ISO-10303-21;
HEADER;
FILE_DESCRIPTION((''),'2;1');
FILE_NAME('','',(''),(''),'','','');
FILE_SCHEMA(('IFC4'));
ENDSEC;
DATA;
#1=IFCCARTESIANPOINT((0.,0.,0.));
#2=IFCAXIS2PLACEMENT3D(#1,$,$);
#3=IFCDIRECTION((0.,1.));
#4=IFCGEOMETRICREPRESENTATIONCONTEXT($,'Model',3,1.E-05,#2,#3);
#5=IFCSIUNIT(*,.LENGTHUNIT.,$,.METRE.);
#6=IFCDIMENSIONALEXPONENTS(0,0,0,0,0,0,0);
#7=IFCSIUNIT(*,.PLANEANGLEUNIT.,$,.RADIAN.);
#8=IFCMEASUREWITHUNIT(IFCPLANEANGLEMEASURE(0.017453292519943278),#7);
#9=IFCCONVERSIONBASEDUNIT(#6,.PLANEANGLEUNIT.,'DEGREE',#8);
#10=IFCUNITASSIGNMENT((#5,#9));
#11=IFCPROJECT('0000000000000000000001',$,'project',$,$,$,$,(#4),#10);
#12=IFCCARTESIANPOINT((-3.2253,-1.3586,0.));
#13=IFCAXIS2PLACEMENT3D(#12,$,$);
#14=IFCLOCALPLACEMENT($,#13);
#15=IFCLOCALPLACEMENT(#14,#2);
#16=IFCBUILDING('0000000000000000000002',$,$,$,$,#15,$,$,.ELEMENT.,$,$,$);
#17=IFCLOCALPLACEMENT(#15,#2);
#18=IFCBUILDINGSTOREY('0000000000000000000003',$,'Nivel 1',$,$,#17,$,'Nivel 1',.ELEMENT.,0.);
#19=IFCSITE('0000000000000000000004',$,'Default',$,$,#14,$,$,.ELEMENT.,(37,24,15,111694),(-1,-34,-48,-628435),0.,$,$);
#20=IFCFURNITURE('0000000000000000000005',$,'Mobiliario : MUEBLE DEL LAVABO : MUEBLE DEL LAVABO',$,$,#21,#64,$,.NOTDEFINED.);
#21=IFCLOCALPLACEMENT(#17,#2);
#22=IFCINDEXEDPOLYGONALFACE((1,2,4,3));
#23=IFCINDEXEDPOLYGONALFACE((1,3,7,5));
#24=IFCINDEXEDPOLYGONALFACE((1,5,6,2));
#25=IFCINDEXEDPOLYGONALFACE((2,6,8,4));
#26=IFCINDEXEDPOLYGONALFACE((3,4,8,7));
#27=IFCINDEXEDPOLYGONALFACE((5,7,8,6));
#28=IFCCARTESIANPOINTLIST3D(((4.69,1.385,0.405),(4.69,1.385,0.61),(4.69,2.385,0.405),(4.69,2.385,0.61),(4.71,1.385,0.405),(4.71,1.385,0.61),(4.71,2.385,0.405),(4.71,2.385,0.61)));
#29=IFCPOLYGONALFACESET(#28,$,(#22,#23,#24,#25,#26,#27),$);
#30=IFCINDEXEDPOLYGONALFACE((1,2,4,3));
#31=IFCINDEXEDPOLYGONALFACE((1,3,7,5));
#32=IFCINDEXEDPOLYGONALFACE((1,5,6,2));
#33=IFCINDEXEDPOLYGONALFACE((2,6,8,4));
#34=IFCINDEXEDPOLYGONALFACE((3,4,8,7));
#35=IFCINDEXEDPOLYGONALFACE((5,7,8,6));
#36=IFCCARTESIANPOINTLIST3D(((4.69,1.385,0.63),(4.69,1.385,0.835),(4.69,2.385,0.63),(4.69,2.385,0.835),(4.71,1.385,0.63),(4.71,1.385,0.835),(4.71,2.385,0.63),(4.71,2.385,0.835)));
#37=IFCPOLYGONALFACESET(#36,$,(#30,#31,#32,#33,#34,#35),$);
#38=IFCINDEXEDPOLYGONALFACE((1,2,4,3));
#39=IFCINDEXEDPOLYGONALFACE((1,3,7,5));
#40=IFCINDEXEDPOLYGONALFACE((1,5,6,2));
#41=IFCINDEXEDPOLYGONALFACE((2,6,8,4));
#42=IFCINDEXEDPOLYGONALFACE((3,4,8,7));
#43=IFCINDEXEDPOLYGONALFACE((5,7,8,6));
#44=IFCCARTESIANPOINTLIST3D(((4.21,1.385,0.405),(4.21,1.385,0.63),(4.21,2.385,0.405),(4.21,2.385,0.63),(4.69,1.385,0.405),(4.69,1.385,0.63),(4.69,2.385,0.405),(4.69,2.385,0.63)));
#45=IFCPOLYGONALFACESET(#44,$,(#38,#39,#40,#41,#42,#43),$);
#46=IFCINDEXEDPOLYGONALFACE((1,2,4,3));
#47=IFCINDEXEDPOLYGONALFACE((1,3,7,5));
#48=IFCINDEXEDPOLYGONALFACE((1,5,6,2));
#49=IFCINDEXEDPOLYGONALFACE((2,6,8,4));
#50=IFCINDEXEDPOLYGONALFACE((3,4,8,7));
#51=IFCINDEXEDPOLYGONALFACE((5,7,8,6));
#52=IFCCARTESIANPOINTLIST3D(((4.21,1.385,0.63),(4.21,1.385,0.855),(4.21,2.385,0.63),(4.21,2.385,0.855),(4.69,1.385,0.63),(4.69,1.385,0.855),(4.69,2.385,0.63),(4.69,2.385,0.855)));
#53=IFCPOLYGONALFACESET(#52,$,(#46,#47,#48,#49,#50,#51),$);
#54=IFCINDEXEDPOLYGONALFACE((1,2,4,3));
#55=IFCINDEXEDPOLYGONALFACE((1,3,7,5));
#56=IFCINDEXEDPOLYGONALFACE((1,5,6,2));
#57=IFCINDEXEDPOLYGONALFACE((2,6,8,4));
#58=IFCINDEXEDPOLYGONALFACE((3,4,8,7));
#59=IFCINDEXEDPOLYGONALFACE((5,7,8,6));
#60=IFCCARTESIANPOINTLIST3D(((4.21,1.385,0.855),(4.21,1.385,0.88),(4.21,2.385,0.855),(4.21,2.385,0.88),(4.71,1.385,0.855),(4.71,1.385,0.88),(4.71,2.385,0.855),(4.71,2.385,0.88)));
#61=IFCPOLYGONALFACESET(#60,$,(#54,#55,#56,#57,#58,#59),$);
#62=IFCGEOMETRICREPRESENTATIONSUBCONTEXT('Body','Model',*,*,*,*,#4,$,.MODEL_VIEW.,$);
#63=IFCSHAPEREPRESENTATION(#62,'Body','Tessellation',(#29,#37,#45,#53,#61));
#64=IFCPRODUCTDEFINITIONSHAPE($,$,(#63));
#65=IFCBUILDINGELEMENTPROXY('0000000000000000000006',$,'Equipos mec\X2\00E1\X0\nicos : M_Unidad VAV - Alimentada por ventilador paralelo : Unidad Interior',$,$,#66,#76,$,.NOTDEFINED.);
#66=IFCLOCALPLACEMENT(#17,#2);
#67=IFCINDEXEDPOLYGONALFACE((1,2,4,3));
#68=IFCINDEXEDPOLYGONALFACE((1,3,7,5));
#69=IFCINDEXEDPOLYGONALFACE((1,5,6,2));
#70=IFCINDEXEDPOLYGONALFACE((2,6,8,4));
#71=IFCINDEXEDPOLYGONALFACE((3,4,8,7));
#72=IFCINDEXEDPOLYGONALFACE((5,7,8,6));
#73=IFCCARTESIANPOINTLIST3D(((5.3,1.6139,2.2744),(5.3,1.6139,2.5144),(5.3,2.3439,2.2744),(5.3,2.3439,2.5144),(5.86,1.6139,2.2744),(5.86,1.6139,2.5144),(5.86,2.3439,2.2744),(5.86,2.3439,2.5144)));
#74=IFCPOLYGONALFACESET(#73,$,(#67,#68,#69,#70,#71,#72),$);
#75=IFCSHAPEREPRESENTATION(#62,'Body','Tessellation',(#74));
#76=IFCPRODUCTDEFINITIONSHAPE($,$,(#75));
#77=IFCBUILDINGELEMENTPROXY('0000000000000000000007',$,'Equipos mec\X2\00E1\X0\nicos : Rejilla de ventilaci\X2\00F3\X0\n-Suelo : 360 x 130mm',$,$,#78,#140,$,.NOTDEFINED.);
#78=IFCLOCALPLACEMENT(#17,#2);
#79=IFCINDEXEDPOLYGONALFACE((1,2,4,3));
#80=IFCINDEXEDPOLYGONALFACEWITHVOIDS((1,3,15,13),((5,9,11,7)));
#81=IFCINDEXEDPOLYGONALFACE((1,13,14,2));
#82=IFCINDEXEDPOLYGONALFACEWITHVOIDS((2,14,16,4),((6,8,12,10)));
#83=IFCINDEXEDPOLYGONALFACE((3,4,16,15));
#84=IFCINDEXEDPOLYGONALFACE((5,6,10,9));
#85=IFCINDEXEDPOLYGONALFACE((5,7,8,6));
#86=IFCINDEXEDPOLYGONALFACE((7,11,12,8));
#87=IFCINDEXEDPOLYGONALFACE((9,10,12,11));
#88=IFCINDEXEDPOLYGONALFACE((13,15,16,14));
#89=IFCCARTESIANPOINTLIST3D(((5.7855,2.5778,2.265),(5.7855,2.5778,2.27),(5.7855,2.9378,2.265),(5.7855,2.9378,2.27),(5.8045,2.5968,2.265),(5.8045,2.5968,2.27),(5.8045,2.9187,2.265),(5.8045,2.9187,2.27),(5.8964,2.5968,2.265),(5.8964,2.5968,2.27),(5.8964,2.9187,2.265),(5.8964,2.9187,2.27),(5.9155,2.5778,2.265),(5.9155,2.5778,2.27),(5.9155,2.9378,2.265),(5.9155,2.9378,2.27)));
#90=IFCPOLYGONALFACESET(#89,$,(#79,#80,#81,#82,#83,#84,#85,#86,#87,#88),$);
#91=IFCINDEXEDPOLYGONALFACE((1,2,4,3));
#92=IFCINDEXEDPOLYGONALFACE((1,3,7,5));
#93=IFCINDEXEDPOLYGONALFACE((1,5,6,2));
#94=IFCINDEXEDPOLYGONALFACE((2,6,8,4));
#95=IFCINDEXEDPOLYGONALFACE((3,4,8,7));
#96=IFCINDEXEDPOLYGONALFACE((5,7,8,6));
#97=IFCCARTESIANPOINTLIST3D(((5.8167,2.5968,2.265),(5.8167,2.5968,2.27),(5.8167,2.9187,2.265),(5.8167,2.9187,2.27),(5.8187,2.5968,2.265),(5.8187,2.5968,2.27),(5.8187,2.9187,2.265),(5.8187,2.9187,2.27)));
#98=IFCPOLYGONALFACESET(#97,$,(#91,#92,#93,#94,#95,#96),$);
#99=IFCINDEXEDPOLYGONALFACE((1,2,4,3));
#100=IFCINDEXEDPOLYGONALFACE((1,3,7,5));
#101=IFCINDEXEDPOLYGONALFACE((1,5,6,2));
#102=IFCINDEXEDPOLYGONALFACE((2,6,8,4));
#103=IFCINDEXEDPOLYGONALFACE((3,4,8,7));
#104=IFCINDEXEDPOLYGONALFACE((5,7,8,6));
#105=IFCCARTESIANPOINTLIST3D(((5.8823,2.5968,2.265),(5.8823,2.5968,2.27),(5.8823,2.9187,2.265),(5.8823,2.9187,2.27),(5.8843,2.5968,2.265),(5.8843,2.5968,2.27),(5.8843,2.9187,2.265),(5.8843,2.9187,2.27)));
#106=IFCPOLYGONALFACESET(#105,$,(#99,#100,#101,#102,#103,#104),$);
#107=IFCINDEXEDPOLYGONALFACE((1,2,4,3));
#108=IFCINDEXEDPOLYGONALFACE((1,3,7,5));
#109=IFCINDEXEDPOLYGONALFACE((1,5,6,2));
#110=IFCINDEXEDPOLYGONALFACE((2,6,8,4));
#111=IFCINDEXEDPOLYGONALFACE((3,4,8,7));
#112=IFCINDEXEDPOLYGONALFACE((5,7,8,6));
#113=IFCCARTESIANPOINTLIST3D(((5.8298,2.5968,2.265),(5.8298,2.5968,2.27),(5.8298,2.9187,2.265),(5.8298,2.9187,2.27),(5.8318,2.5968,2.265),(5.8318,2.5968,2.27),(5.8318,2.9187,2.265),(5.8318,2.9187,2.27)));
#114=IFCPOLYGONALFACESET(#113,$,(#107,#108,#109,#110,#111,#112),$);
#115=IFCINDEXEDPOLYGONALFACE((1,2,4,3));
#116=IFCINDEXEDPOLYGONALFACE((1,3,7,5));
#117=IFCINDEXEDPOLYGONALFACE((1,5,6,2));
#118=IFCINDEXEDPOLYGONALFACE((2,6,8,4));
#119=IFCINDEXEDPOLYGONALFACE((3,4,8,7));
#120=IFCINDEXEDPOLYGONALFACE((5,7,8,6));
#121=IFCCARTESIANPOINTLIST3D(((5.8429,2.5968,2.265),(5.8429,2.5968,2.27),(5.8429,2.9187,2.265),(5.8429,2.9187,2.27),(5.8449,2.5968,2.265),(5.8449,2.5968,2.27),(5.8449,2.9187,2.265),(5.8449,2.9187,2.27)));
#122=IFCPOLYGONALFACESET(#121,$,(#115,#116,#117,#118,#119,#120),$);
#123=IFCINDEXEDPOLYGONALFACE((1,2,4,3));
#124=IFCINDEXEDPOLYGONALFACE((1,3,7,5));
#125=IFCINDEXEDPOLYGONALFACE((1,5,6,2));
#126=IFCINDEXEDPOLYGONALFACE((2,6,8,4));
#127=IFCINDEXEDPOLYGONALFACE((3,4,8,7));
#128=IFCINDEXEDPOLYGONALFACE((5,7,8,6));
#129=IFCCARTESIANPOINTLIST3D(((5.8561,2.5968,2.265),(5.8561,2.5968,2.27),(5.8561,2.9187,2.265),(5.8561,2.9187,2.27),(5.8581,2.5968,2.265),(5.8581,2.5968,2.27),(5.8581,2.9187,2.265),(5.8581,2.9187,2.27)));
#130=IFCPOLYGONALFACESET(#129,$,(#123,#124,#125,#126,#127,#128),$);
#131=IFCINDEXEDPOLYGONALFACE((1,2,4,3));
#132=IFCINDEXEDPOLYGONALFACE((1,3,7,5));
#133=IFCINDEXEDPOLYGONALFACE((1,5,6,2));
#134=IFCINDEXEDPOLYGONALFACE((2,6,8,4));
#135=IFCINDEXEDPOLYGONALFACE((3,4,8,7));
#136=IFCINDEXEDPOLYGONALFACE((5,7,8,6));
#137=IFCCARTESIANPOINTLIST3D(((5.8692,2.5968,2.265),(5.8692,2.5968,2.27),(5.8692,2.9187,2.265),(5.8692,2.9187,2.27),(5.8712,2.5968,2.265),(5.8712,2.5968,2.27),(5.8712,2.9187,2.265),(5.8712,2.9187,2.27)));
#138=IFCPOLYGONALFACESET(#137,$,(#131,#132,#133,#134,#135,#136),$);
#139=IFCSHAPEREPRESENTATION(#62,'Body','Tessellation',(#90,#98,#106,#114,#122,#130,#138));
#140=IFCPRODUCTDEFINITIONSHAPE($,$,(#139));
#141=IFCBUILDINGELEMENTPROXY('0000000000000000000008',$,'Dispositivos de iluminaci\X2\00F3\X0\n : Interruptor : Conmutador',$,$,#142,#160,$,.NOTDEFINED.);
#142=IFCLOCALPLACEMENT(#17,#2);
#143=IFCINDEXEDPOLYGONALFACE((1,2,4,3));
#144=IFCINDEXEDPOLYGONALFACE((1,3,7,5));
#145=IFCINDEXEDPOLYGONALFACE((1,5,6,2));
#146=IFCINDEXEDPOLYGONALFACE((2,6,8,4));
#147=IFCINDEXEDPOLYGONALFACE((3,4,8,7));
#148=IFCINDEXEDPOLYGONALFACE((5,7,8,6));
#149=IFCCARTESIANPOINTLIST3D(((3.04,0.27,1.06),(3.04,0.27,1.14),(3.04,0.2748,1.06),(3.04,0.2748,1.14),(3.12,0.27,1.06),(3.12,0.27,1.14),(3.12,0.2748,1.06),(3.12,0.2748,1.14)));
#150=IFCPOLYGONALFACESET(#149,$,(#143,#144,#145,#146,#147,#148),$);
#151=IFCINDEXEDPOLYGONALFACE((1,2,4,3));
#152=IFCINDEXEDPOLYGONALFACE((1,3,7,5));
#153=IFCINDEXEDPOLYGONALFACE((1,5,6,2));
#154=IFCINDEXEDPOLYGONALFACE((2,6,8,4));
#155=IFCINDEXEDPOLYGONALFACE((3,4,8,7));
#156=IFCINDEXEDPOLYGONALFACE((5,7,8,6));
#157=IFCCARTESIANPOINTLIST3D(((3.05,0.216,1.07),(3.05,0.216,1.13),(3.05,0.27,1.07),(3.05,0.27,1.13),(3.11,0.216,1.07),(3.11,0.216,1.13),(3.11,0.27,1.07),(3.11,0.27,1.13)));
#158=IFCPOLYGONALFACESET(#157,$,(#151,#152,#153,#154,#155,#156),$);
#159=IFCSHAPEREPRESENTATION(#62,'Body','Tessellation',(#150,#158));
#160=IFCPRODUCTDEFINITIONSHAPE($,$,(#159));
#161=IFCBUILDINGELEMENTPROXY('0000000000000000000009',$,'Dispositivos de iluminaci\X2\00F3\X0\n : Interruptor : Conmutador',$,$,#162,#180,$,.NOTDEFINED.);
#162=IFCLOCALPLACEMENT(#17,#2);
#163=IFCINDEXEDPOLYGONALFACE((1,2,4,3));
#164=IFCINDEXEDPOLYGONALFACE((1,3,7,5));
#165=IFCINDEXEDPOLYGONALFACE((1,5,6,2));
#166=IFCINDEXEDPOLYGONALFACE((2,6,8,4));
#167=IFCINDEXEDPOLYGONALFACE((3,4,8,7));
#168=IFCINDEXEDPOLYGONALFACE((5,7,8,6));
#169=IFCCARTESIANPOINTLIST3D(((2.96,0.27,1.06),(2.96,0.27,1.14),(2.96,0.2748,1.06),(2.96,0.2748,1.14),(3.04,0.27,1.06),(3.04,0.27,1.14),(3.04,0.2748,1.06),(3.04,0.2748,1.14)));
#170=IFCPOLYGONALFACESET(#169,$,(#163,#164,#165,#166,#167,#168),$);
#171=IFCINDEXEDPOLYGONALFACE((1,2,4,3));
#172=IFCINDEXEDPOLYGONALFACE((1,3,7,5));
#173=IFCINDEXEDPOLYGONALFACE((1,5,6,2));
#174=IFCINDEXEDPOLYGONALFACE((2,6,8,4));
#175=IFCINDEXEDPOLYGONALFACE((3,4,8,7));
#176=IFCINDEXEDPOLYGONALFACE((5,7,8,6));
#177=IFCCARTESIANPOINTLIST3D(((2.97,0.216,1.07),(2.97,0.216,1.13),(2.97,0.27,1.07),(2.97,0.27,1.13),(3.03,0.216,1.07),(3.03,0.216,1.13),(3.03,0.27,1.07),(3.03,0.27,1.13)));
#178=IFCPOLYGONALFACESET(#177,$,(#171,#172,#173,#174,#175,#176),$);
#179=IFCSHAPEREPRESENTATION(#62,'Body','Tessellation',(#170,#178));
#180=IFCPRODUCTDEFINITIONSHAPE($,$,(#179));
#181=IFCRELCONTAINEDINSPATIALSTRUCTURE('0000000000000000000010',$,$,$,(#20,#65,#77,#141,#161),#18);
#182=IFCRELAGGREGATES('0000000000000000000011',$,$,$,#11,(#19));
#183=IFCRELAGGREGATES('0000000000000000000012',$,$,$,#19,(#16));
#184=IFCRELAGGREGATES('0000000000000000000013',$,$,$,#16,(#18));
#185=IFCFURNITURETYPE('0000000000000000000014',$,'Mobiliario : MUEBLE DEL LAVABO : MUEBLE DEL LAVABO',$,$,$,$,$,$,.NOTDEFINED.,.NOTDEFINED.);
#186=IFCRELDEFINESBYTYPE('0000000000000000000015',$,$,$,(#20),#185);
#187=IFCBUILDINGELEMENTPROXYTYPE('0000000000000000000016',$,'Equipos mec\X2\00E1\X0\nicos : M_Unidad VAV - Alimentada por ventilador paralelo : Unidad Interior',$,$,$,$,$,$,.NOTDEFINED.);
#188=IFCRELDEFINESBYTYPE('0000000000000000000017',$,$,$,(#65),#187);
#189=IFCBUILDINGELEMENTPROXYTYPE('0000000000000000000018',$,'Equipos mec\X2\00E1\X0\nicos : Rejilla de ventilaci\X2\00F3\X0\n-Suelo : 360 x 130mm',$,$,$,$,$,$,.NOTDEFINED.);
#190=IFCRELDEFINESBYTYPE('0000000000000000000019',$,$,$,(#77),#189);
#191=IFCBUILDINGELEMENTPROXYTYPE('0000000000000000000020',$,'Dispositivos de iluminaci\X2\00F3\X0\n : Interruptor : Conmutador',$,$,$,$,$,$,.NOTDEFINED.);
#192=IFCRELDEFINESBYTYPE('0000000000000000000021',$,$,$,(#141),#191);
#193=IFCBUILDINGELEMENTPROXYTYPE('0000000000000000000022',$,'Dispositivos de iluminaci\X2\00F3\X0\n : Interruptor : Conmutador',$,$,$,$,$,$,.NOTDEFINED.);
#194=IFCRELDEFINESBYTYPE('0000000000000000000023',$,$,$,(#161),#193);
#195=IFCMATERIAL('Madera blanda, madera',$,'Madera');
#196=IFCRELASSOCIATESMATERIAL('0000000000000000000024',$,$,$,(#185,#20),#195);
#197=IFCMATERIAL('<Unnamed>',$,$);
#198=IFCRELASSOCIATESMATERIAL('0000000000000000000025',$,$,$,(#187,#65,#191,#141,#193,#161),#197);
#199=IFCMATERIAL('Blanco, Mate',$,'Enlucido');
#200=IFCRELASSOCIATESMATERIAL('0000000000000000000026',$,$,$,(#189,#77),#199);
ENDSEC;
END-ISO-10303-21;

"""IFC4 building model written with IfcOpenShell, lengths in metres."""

from ifc_helpers import new_model, entity, si_unit, converted_unit, direction, frame, origin, place, context, subcontext, project, spatial, indexed_curve, outline, extrude, source, transform, mapped, material, type_object, type_shapes, element, save


model = new_model("IFC4")

# Units and contexts
model_context = context("Model", 3, precision=1e-05, world=origin(), true_north=direction((0.0, 1.0)))
body_context = subcontext(model_context, "Body", "Model", "MODEL_VIEW")
ifc_project = project(units=[si_unit("LENGTHUNIT", "METRE"), converted_unit("PLANEANGLEUNIT", "DEGREE", entity("IfcPlaneAngleMeasure", 0.017453292519943278), si_unit("PLANEANGLEUNIT", "RADIAN"), dimensions=[0, 0, 0, 0, 0, 0, 0])], contexts=[model_context])

# Site, building, storey
site_placement = place(None, frame((-3.2253, -1.3586, 0.0)))
site = spatial("IfcSite", under=ifc_project, at=site_placement, Name="Default", CompositionType="ELEMENT", RefLatitude=(37, 24, 15, 111694), RefLongitude=(-1, -34, -48, -628435), RefElevation=0.0)
building_placement = place(site_placement, origin())
building = spatial("IfcBuilding", under=site, at=building_placement, CompositionType="ELEMENT")
storey_placement = place(building_placement, origin())
storey = spatial("IfcBuildingStorey", under=building, at=storey_placement, Name="Nivel 1", LongName="Nivel 1", CompositionType="ELEMENT", Elevation=0.0)

# Shared definitions
ifc_material_1 = material(Name="Blanco, Mate", Category="Enlucido")

# Shared definitions
ifc_material_2 = material(Name="<Unnamed>")

# Furniture
ifc_material_3 = material(Name="Madera blanda, madera", Category="Madera")
furniture_type_1 = type_object("IfcFurnitureType", Name="Mobiliario : MUEBLE DEL LAVABO : MUEBLE DEL LAVABO", AssemblyPlace="NOTDEFINED", PredefinedType="NOTDEFINED", material=ifc_material_3)
shared_shape_1 = source(origin(), body_context, "Body", "SweptSolid", [
    extrude(outline(indexed_curve([(-0.01, -0.5), (0.01, -0.5), (0.01, 0.5), (-0.01, 0.5), (-0.01, -0.5)], self_intersect=False)), frame((1.4747, 0.5264, 0.405), z_axis=(0.0, 0.0, 1.0), x_axis=(-1.0, 0.0, 0.0)), (0.0, 0.0, 1.0), 0.205),
    extrude(outline(indexed_curve([(-0.01, -0.5), (0.01, -0.5), (0.01, 0.5), (-0.01, 0.5), (-0.01, -0.5)], self_intersect=False)), frame((1.4747, 0.5264, 0.63), z_axis=(0.0, 0.0, 1.0), x_axis=(-1.0, 0.0, 0.0)), (0.0, 0.0, 1.0), 0.205),
    extrude(outline(indexed_curve([(-0.24, -0.5), (0.24, -0.5), (0.24, 0.5), (-0.24, 0.5), (-0.24, -0.5)], self_intersect=False)), frame((1.2247, 0.5264, 0.405), z_axis=(0.0, 0.0, 1.0), x_axis=(-1.0, 0.0, 0.0)), (0.0, 0.0, 1.0), 0.225),
    extrude(outline(indexed_curve([(-0.24, -0.5), (0.24, -0.5), (0.24, 0.5), (-0.24, 0.5), (-0.24, -0.5)], self_intersect=False)), frame((1.2247, 0.5264, 0.63), z_axis=(0.0, 0.0, 1.0), x_axis=(-1.0, 0.0, 0.0)), (0.0, 0.0, 1.0), 0.225),
    extrude(outline(indexed_curve([(-0.25, -0.5), (0.25, -0.5), (0.25, 0.5), (-0.25, 0.5), (-0.25, -0.5)], self_intersect=False)), frame((1.2347, 0.5264, 0.855), z_axis=(0.0, 0.0, 1.0), x_axis=(-1.0, 0.0, 0.0)), (0.0, 0.0, 1.0), 0.025),
])
type_shapes(furniture_type_1, [shared_shape_1])
furniture_1_placement = place(storey_placement, frame((3.2253, 1.3586, 0.0)))
element("IfcFurniture", 1, at=furniture_1_placement, inside=storey, type_object=furniture_type_1, material=ifc_material_3, Name="Mobiliario : MUEBLE DEL LAVABO : MUEBLE DEL LAVABO", PredefinedType="NOTDEFINED", context=body_context, shape_type="MappedRepresentation", body=[
    mapped(shared_shape_1, transform((0.0, 0.0, 0.0), scale=1.0)),
])

# Building element proxies
building_element_proxy_type_1 = type_object("IfcBuildingElementProxyType", Name="Equipos mecánicos : M_Unidad VAV - Alimentada por ventilador paralelo : Unidad Interior", PredefinedType="NOTDEFINED", material=ifc_material_2)
shared_shape_2 = source(origin(), body_context, "Body", "SweptSolid", [
    extrude(outline(indexed_curve([(-0.365, -0.28), (0.365, -0.28), (0.365, 0.28), (-0.365, 0.28), (-0.365, -0.28)], self_intersect=False)), frame((0.0, 0.0, -0.12), z_axis=(0.0, 0.0, 1.0), x_axis=(0.0, 1.0, 0.0)), (0.0, 0.0, 1.0), 0.24),
])
type_shapes(building_element_proxy_type_1, [shared_shape_2])
proxy_1_placement = place(storey_placement, frame((5.58, 1.9789, 2.3944), z_axis=(0.0, 0.0, 1.0), x_axis=(-1.0, 0.0, 0.0)))
element("IfcBuildingElementProxy", 2, at=proxy_1_placement, inside=storey, type_object=building_element_proxy_type_1, material=ifc_material_2, Name="Equipos mecánicos : M_Unidad VAV - Alimentada por ventilador paralelo : Unidad Interior", PredefinedType="NOTDEFINED", context=body_context, shape_type="MappedRepresentation", body=[
    mapped(shared_shape_2, transform((0.0, 0.0, 0.0), scale=1.0)),
])
building_element_proxy_type_2 = type_object("IfcBuildingElementProxyType", Name="Equipos mecánicos : Rejilla de ventilación-Suelo : 360 x 130mm", PredefinedType="NOTDEFINED", material=ifc_material_1)
shared_shape_3 = source(origin(), body_context, "Body", "SweptSolid", [
    extrude(outline(indexed_curve([(-0.065, -0.18), (0.065, -0.18), (0.065, 0.18), (-0.065, 0.18), (-0.065, -0.18)], self_intersect=False), holes=[indexed_curve([(-0.0459, -0.1609), (-0.0459, 0.1609), (0.046, 0.1609), (0.046, -0.1609), (-0.0459, -0.1609)], self_intersect=False)]), frame((-0.0022, 0.0015, 0.0), z_axis=(0.0, 0.0, 1.0), x_axis=(0.0, 1.0, 0.0)), (0.0, 0.0, 1.0), 0.005),
    extrude(outline(indexed_curve([(-0.001, -0.1609), (0.001, -0.1609), (0.001, 0.1609), (-0.001, 0.1609), (-0.001, -0.1609)], self_intersect=False)), frame((-0.0022, -0.0313, 0.0), z_axis=(0.0, 0.0, 1.0), x_axis=(0.0, 1.0, 0.0)), (0.0, 0.0, 1.0), 0.005),
    extrude(outline(indexed_curve([(-0.001, -0.1609), (0.001, -0.1609), (0.001, 0.1609), (-0.001, 0.1609), (-0.001, -0.1609)], self_intersect=False)), frame((-0.0022, 0.0343, 0.0), z_axis=(0.0, 0.0, 1.0), x_axis=(0.0, 1.0, 0.0)), (0.0, 0.0, 1.0), 0.005),
    extrude(outline(indexed_curve([(-0.001, -0.1609), (0.001, -0.1609), (0.001, 0.1609), (-0.001, 0.1609), (-0.001, -0.1609)], self_intersect=False)), frame((-0.0022, -0.0182, 0.0), z_axis=(0.0, 0.0, 1.0), x_axis=(0.0, 1.0, 0.0)), (0.0, 0.0, 1.0), 0.005),
    extrude(outline(indexed_curve([(-0.001, -0.1609), (0.001, -0.1609), (0.001, 0.1609), (-0.001, 0.1609), (-0.001, -0.1609)], self_intersect=False)), frame((-0.0022, -0.0051, 0.0), z_axis=(0.0, 0.0, 1.0), x_axis=(0.0, 1.0, 0.0)), (0.0, 0.0, 1.0), 0.005),
    extrude(outline(indexed_curve([(-0.001, -0.1609), (0.001, -0.1609), (0.001, 0.1609), (-0.001, 0.1609), (-0.001, -0.1609)], self_intersect=False)), frame((-0.0022, 0.0081, 0.0), z_axis=(0.0, 0.0, 1.0), x_axis=(0.0, 1.0, 0.0)), (0.0, 0.0, 1.0), 0.005),
    extrude(outline(indexed_curve([(-0.001, -0.1609), (0.001, -0.1609), (0.001, 0.1609), (-0.001, 0.1609), (-0.001, -0.1609)], self_intersect=False)), frame((-0.0022, 0.0212, 0.0), z_axis=(0.0, 0.0, 1.0), x_axis=(0.0, 1.0, 0.0)), (0.0, 0.0, 1.0), 0.005),
])
type_shapes(building_element_proxy_type_2, [shared_shape_3])
proxy_2_placement = place(storey_placement, frame((5.849, 2.76, 2.27), z_axis=(0.0, 0.0, -1.0), x_axis=(0.0, 1.0, 0.0)))
element("IfcBuildingElementProxy", 3, at=proxy_2_placement, inside=storey, type_object=building_element_proxy_type_2, material=ifc_material_1, Name="Equipos mecánicos : Rejilla de ventilación-Suelo : 360 x 130mm", PredefinedType="NOTDEFINED", context=body_context, shape_type="MappedRepresentation", body=[
    mapped(shared_shape_3, transform((0.0, 0.0, 0.0), scale=1.0)),
])
building_element_proxy_type_3 = type_object("IfcBuildingElementProxyType", Name="Dispositivos de iluminación : Interruptor : Conmutador", PredefinedType="NOTDEFINED", material=ifc_material_2)
shared_shape_4 = source(origin(), body_context, "Body", "SweptSolid", [
    extrude(outline(indexed_curve([(-0.04, -0.04), (0.04, -0.04), (0.04, 0.04), (-0.04, 0.04), (-0.04, -0.04)], self_intersect=False)), frame((0.0, 0.0, 0.0), z_axis=(0.0, 0.0, 1.0), x_axis=(0.0, -1.0, 0.0)), (0.0, 0.0, 1.0), 0.0048),
    extrude(outline(indexed_curve([(-0.03, -0.03), (0.03, -0.03), (0.03, 0.03), (-0.03, 0.03), (-0.03, -0.03)], self_intersect=False)), frame((0.0, 0.0, -0.054), z_axis=(0.0, 0.0, 1.0), x_axis=(-1.0, 0.0, 0.0)), (0.0, 0.0, 1.0), 0.054),
])
type_shapes(building_element_proxy_type_3, [shared_shape_4])
proxy_3_placement = place(storey_placement, frame((3.08, 0.27, 1.1), z_axis=(0.0, 1.0, 0.0), x_axis=(-1.0, 0.0, 0.0)))
element("IfcBuildingElementProxy", 4, at=proxy_3_placement, inside=storey, type_object=building_element_proxy_type_3, material=ifc_material_2, Name="Dispositivos de iluminación : Interruptor : Conmutador", PredefinedType="NOTDEFINED", context=body_context, shape_type="MappedRepresentation", body=[
    mapped(shared_shape_4, transform((0.0, 0.0, 0.0), scale=1.0)),
])
building_element_proxy_type_4 = type_object("IfcBuildingElementProxyType", Name="Dispositivos de iluminación : Interruptor : Conmutador", PredefinedType="NOTDEFINED", material=ifc_material_2)
shared_shape_5 = source(origin(), body_context, "Body", "SweptSolid", [
    extrude(outline(indexed_curve([(-0.04, -0.04), (0.04, -0.04), (0.04, 0.04), (-0.04, 0.04), (-0.04, -0.04)], self_intersect=False)), frame((0.0, 0.0, 0.0), z_axis=(0.0, 0.0, 1.0), x_axis=(0.0, -1.0, 0.0)), (0.0, 0.0, 1.0), 0.0048),
    extrude(outline(indexed_curve([(-0.03, -0.03), (0.03, -0.03), (0.03, 0.03), (-0.03, 0.03), (-0.03, -0.03)], self_intersect=False)), frame((0.0, 0.0, -0.054), z_axis=(0.0, 0.0, 1.0), x_axis=(-1.0, 0.0, 0.0)), (0.0, 0.0, 1.0), 0.054),
])
type_shapes(building_element_proxy_type_4, [shared_shape_5])
for number, where, z_axis, x_axis, name in (
    (5, (3.0, 0.27, 1.1), (0.0, 1.0, 0.0), (-1.0, 0.0, 0.0), "Dispositivos de iluminación : Interruptor : Conmutador"),
):
    element("IfcBuildingElementProxy", number, at=place(storey_placement, frame(where, z_axis=z_axis, x_axis=x_axis)), inside=storey, type_object=building_element_proxy_type_4, material=ifc_material_2, Name=name, PredefinedType="NOTDEFINED", context=body_context, shape_type="MappedRepresentation", body=[
        mapped(shared_shape_5, transform((0.0, 0.0, 0.0), scale=1.0)),
    ])

save(model, "model.ifc")
